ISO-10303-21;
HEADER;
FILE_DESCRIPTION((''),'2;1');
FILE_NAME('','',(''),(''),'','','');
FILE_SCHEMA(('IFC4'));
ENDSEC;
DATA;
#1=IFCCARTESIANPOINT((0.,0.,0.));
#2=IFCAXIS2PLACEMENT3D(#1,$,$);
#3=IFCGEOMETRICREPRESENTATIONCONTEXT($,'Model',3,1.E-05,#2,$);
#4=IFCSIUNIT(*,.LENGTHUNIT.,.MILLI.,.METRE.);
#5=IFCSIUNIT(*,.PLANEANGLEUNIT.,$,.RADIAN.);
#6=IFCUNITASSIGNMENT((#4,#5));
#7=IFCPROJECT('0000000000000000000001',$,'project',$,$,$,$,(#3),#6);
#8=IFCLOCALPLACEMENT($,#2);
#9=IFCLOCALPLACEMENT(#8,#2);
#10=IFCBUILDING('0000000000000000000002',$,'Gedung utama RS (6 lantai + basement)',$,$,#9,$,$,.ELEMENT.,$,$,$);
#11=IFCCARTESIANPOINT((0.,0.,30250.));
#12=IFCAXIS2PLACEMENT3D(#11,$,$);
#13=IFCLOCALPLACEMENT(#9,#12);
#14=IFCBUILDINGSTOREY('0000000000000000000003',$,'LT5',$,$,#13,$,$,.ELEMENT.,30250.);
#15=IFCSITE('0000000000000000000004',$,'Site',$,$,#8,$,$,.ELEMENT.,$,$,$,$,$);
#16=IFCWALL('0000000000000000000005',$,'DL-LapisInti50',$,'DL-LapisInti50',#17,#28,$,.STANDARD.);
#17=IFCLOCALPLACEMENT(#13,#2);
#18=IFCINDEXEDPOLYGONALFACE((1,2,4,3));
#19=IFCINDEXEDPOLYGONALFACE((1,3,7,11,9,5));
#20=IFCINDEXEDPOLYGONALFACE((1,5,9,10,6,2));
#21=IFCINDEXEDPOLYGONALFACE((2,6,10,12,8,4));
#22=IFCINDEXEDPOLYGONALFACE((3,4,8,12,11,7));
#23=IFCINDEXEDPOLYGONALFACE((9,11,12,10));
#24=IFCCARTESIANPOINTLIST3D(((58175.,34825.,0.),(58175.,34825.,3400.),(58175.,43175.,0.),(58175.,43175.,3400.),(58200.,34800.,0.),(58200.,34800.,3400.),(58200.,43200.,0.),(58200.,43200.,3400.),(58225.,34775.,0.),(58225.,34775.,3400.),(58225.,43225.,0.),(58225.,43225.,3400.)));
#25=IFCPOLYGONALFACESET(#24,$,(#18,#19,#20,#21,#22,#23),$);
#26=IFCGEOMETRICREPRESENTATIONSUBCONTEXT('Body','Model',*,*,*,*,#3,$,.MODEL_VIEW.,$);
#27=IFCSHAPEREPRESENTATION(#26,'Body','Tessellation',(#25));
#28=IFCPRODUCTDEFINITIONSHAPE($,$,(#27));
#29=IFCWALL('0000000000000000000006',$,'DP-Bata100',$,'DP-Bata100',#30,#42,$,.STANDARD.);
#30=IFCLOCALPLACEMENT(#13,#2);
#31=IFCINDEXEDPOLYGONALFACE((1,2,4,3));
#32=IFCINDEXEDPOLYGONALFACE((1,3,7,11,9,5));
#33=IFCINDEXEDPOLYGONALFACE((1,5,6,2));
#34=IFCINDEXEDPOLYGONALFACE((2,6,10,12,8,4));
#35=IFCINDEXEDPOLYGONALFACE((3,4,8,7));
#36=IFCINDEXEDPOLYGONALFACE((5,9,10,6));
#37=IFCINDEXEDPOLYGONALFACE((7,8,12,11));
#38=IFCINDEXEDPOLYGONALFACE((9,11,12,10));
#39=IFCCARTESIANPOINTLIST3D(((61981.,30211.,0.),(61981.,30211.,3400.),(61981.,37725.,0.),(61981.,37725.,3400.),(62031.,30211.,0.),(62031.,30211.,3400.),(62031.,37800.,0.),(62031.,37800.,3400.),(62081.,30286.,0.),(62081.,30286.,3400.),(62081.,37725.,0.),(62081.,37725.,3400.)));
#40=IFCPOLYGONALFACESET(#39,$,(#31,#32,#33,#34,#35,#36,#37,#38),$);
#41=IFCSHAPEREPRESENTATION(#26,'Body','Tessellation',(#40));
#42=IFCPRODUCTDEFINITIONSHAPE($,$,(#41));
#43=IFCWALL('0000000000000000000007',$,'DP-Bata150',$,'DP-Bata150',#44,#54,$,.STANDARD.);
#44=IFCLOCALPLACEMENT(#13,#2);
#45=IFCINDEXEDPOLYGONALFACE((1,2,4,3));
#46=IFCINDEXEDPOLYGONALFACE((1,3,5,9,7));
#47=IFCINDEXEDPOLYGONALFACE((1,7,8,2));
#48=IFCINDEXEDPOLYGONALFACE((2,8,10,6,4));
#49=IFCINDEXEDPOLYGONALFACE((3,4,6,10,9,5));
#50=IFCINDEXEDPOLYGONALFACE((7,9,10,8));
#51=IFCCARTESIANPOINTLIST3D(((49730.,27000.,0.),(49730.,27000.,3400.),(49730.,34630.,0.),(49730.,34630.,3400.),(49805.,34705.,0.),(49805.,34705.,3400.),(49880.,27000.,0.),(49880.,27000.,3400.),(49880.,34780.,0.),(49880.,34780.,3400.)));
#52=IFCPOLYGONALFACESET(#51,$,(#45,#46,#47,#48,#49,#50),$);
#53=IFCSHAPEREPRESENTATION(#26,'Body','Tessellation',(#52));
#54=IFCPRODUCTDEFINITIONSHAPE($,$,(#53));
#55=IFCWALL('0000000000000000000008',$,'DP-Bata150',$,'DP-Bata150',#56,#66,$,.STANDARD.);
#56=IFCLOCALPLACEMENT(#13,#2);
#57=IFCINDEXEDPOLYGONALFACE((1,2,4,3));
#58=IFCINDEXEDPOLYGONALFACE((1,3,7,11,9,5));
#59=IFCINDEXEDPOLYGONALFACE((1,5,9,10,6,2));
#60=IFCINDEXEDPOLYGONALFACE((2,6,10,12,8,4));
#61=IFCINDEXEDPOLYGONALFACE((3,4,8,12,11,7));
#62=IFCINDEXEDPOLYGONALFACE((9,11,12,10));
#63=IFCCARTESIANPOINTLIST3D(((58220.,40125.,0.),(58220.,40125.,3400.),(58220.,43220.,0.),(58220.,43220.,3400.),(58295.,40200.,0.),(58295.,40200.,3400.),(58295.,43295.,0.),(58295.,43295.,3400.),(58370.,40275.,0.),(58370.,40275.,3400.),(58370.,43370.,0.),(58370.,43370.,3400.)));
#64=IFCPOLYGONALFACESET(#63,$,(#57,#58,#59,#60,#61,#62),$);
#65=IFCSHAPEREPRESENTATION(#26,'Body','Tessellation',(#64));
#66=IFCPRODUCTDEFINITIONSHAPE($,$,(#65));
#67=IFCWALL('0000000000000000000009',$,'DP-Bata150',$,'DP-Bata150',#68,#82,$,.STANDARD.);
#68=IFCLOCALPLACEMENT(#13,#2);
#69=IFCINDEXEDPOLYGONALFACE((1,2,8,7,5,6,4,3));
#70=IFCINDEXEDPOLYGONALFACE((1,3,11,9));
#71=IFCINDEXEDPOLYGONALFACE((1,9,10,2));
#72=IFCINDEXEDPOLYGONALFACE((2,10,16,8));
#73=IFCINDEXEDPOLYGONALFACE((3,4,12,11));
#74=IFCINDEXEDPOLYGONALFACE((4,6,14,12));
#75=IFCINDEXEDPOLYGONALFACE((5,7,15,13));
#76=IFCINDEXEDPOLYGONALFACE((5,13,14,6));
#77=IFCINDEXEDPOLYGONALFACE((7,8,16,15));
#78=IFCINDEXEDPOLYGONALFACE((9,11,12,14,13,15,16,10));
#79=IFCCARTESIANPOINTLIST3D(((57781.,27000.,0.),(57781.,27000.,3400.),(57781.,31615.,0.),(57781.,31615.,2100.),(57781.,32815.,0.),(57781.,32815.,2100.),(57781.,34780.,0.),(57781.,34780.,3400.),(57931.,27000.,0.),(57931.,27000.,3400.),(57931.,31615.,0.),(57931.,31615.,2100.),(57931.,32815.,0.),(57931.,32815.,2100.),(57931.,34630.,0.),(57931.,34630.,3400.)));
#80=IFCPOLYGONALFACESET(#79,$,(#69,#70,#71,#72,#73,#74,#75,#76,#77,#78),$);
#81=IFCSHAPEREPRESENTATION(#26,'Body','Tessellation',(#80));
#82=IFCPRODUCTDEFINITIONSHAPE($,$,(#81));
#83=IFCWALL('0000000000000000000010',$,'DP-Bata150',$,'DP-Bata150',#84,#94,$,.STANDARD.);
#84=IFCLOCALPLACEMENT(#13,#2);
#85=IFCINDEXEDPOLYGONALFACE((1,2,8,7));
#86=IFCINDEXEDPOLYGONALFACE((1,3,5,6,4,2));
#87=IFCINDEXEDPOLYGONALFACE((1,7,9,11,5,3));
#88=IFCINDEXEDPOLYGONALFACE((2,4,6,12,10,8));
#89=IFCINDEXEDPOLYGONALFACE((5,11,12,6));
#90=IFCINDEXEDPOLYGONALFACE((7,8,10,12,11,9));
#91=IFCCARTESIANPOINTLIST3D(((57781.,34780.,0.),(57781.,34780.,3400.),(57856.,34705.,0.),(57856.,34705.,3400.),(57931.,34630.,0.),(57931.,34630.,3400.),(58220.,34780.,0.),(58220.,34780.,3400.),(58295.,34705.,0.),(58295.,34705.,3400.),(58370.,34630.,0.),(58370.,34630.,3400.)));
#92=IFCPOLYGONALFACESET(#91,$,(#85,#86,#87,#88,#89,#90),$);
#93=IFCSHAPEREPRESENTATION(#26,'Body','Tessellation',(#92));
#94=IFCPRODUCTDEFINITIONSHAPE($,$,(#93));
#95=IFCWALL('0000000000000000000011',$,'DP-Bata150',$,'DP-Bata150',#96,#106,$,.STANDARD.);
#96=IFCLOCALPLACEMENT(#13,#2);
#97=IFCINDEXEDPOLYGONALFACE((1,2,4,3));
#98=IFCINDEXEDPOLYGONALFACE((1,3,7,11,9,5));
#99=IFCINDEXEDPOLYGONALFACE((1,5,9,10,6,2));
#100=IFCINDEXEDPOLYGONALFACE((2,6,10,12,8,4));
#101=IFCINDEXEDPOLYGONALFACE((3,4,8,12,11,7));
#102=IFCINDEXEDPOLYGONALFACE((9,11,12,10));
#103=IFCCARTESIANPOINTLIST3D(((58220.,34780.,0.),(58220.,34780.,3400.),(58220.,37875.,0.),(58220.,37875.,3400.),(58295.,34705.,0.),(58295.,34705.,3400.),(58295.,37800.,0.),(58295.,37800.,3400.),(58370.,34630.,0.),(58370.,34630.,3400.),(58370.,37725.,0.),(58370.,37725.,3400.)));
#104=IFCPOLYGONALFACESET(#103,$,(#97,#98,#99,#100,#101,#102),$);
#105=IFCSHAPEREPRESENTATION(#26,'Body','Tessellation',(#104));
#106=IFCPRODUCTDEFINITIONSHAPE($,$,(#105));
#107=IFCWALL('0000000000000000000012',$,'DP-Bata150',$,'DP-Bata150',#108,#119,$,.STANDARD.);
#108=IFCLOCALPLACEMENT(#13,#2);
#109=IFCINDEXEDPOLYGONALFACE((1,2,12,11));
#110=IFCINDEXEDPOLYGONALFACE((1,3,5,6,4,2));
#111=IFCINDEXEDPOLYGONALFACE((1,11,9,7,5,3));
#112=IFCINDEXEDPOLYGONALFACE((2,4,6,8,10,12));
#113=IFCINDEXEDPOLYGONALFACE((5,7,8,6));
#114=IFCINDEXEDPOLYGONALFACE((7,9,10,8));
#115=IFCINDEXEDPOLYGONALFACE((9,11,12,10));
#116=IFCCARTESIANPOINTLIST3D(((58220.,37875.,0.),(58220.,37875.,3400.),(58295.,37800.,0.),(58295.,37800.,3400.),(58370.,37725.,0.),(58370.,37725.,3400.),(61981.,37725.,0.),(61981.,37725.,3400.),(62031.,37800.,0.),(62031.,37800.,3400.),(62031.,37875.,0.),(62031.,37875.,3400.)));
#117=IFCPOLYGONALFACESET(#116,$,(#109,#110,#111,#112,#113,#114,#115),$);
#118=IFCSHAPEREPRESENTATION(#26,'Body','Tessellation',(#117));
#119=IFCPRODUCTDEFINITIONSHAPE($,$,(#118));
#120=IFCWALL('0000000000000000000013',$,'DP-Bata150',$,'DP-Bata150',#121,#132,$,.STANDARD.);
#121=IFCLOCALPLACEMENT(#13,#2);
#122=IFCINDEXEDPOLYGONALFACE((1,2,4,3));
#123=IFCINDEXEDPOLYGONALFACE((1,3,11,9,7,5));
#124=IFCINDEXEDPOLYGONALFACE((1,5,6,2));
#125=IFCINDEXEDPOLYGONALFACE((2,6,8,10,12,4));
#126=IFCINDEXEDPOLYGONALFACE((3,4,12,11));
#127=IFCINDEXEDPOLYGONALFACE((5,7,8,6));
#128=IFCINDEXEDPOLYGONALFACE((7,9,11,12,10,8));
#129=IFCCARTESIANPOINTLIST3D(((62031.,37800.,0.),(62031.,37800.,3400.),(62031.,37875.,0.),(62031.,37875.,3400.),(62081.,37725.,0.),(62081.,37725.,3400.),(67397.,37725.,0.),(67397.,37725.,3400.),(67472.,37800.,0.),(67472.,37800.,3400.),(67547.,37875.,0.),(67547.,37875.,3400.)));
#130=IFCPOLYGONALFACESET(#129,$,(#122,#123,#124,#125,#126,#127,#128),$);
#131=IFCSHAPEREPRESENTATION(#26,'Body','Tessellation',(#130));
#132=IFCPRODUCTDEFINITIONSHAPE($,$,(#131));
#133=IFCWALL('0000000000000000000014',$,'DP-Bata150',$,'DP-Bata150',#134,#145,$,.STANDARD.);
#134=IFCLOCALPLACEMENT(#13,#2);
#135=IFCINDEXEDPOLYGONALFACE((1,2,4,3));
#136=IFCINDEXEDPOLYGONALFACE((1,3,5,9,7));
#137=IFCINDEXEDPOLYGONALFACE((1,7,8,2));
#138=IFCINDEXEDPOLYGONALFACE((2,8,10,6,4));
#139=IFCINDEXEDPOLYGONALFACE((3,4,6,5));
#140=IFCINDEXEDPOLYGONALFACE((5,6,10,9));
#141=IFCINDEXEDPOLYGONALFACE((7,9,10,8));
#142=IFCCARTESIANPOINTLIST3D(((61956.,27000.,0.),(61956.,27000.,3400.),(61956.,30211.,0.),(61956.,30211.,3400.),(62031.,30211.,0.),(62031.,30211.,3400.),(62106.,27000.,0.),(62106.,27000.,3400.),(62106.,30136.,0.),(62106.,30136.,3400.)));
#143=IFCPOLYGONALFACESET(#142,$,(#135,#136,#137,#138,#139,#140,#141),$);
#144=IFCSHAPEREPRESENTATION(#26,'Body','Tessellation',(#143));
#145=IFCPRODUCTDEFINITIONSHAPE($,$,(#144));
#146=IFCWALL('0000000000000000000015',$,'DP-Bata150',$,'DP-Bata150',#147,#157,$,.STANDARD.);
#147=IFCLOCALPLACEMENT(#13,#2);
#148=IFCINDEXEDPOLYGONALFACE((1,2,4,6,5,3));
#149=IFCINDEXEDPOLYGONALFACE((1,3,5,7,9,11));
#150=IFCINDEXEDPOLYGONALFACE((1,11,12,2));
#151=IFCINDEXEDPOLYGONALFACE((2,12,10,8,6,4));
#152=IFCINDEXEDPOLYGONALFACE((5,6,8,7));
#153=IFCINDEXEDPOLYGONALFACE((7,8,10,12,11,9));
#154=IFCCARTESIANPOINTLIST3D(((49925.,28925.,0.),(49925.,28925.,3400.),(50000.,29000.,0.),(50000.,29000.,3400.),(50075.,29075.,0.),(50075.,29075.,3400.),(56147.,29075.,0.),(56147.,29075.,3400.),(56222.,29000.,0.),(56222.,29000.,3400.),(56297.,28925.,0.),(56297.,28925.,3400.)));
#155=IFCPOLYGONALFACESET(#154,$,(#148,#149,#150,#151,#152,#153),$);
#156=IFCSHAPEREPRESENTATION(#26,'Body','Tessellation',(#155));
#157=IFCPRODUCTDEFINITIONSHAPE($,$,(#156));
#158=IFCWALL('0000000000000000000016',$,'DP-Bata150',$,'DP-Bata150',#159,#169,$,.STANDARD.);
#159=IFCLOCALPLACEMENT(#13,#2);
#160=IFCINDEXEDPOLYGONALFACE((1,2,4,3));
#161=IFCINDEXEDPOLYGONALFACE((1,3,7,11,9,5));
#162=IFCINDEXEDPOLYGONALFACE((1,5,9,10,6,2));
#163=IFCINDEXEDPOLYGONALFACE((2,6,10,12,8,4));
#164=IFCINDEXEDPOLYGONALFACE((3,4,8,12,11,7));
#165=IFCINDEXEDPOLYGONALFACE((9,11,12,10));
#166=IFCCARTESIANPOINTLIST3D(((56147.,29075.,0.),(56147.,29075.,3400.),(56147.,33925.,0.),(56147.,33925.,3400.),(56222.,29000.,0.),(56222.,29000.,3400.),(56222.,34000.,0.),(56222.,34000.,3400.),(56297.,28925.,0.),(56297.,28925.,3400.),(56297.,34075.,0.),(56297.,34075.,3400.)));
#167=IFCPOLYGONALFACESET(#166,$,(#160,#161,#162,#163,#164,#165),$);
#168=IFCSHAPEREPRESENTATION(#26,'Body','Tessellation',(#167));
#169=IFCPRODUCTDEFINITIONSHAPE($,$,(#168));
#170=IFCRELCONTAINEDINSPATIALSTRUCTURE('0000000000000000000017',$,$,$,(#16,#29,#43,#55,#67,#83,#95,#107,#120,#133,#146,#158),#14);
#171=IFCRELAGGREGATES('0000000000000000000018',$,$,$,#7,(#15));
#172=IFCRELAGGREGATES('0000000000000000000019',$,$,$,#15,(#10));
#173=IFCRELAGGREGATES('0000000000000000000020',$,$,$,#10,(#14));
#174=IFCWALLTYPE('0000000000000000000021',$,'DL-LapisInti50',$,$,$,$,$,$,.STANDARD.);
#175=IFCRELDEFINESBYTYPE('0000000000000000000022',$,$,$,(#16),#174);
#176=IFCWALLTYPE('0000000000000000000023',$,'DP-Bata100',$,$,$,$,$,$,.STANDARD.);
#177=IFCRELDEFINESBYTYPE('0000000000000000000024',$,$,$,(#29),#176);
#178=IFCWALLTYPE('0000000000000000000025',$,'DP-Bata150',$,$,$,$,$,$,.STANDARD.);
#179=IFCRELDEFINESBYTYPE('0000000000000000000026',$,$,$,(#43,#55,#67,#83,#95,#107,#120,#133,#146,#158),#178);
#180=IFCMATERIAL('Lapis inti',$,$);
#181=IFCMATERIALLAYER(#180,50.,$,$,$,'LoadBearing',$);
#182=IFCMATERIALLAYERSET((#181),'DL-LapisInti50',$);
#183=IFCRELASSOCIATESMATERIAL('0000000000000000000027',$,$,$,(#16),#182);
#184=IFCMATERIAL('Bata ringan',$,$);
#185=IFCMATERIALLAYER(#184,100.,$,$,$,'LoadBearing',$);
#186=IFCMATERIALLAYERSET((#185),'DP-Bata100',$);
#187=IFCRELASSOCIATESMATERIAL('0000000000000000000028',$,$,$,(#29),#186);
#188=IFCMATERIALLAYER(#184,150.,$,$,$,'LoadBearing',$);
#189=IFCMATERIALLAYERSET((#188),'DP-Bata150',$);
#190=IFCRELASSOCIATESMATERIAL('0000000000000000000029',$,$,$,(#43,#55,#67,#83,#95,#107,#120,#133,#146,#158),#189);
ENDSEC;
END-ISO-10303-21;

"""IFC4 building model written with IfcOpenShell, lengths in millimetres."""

from ifc_helpers import new_model, si_unit, frame, frame_2d, origin, place, context, subcontext, project, spatial, polyline, rectangle, outline, extrude, material, layer, layer_set, layer_usage, type_object, element, save


model = new_model("IFC4")

# Units and contexts
model_context = context("Model", 3, precision=1e-05, world=origin())
body_context = subcontext(model_context, "Body", "Model", "MODEL_VIEW")
ifc_project = project(units=[si_unit("LENGTHUNIT", "METRE", prefix="MILLI"), si_unit("PLANEANGLEUNIT", "RADIAN")], contexts=[model_context])

# Site, building, storey
site_placement = place(None, origin())
site = spatial("IfcSite", under=ifc_project, at=site_placement, Name="Site", CompositionType="ELEMENT")
building_placement = place(site_placement, origin())
building = spatial("IfcBuilding", under=site, at=building_placement, Name="Gedung utama RS (6 lantai + basement)", CompositionType="ELEMENT")
storey_placement = place(building_placement, frame((0.0, 0.0, 30250.0)))
storey = spatial("IfcBuildingStorey", under=building, at=storey_placement, Name="LT5", CompositionType="ELEMENT", Elevation=30250.0)

# Walls
ifc_material_1 = material(Name="Lapis inti")
ifc_layer_1 = layer(ifc_material_1, 50.0, Category="LoadBearing")
ifc_layer_set_1 = layer_set([ifc_layer_1], Name="DL-LapisInti50")
ifc_layer_usage_1 = layer_usage(ifc_layer_set_1, "AXIS2", "NEGATIVE", 25.0)
wall_type_1 = type_object("IfcWallType", Name="DL-LapisInti50", PredefinedType="STANDARD")
wall_1_placement = place(storey_placement, frame((58200.0, 34800.0, 0.0), z_axis=(0.0, 0.0, 1.0), x_axis=(0.0, 1.0, 0.0)))
element("IfcWall", 1, at=wall_1_placement, inside=storey, type_object=wall_type_1, material=ifc_layer_usage_1, Name="DL-LapisInti50", ObjectType="DL-LapisInti50", PredefinedType="STANDARD", context=body_context, shape_type="SweptSolid", body=[
    extrude(outline(polyline([(-25.0, -25.0), (0.0, 0.0), (25.0, 25.0), (8375.0, 25.0), (8400.0, 0.0), (8425.0, -25.0), (-25.0, -25.0)])), origin(), (0.0, 0.0, 1.0), 3400.0),
])
ifc_material_2 = material(Name="Bata ringan")
ifc_layer_2 = layer(ifc_material_2, 100.0, Category="LoadBearing")
ifc_layer_set_2 = layer_set([ifc_layer_2], Name="DP-Bata100")
ifc_layer_usage_2 = layer_usage(ifc_layer_set_2, "AXIS2", "NEGATIVE", 50.0)
wall_type_2 = type_object("IfcWallType", Name="DP-Bata100", PredefinedType="STANDARD")
wall_2_placement = place(storey_placement, frame((62031.0, 37800.0, 0.0), z_axis=(0.0, 0.0, 1.0), x_axis=(0.0, -1.0, 0.0)))
element("IfcWall", 2, at=wall_2_placement, inside=storey, type_object=wall_type_2, material=ifc_layer_usage_2, Name="DP-Bata100", ObjectType="DP-Bata100", PredefinedType="STANDARD", context=body_context, shape_type="SweptSolid", body=[
    extrude(outline(polyline([(75.0, -50.0), (0.0, 0.0), (75.0, 50.0), (7514.0, 50.0), (7589.0, 0.0), (7589.0, -50.0), (75.0, -50.0)])), origin(), (0.0, 0.0, 1.0), 3400.0),
])
ifc_layer_3 = layer(ifc_material_2, 150.0, Category="LoadBearing")
ifc_layer_set_3 = layer_set([ifc_layer_3], Name="DP-Bata150")
ifc_layer_usage_3 = layer_usage(ifc_layer_set_3, "AXIS2", "NEGATIVE", 75.0)
wall_type_3 = type_object("IfcWallType", Name="DP-Bata150", PredefinedType="STANDARD")
wall_3_placement = place(storey_placement, frame((49805.0, 34705.0, 0.0), z_axis=(0.0, 0.0, 1.0), x_axis=(0.0, -1.0, 0.0)))
element("IfcWall", 3, at=wall_3_placement, inside=storey, type_object=wall_type_3, material=ifc_layer_usage_3, Name="DP-Bata150", ObjectType="DP-Bata150", PredefinedType="STANDARD", context=body_context, shape_type="SweptSolid", body=[
    extrude(outline(polyline([(75.0, -75.0), (0.0, 0.0), (-75.0, 75.0), (7705.0, 75.0), (7705.0, -75.0), (75.0, -75.0)])), origin(), (0.0, 0.0, 1.0), 3400.0),
])
wall_4_placement = place(storey_placement, frame((58295.0, 40200.0, 0.0), z_axis=(0.0, 0.0, 1.0), x_axis=(0.0, 1.0, 0.0)))
element("IfcWall", 4, at=wall_4_placement, inside=storey, type_object=wall_type_3, material=ifc_layer_usage_3, Name="DP-Bata150", ObjectType="DP-Bata150", PredefinedType="STANDARD", context=body_context, shape_type="SweptSolid", body=[
    extrude(outline(polyline([(75.0, -75.0), (0.0, 0.0), (-75.0, 75.0), (3020.0, 75.0), (3095.0, 0.0), (3170.0, -75.0), (75.0, -75.0)])), origin(), (0.0, 0.0, 1.0), 3400.0),
])

# Wall, opening
wall_5_placement = place(storey_placement, frame((57856.0, 27000.0, 0.0), z_axis=(0.0, 0.0, 1.0), x_axis=(0.0, 1.0, 0.0)))
wall_5 = element("IfcWall", 5, at=wall_5_placement, inside=storey, type_object=wall_type_3, material=ifc_layer_usage_3, Name="DP-Bata150", ObjectType="DP-Bata150", PredefinedType="STANDARD", context=body_context, shape_type="SweptSolid", body=[
    extrude(outline(polyline([(0.0, -75.0), (0.0, 75.0), (7780.0, 75.0), (7705.0, 0.0), (7630.0, -75.0), (0.0, -75.0)])), origin(), (0.0, 0.0, 1.0), 3400.0),
])
opening_1_placement = place(wall_5_placement, frame((4615.0, 0.0, 0.0), z_axis=(0.0, 0.0, 1.0), x_axis=(1.0, 0.0, 0.0)))
element("IfcOpeningElement", 6, at=opening_1_placement, cuts=wall_5, PredefinedType="OPENING", context=body_context, shape_type="SweptSolid", body=[
    extrude(rectangle(XDim=1200.0, YDim=170.0, at=frame_2d((600.0, 0.0))), origin(), (0.0, 0.0, 1.0), 2100.0),
])

# Walls
wall_6_placement = place(storey_placement, frame((57856.0, 34705.0, 0.0), z_axis=(0.0, 0.0, 1.0), x_axis=(1.0, 0.0, 0.0)))
element("IfcWall", 7, at=wall_6_placement, inside=storey, type_object=wall_type_3, material=ifc_layer_usage_3, Name="DP-Bata150", ObjectType="DP-Bata150", PredefinedType="STANDARD", context=body_context, shape_type="SweptSolid", body=[
    extrude(outline(polyline([(75.0, -75.0), (0.0, 0.0), (-75.0, 75.0), (364.0, 75.0), (439.0, 0.0), (514.0, -75.0), (75.0, -75.0)])), origin(), (0.0, 0.0, 1.0), 3400.0),
])
wall_7_placement = place(storey_placement, frame((58295.0, 34705.0, 0.0), z_axis=(0.0, 0.0, 1.0), x_axis=(0.0, 1.0, 0.0)))
element("IfcWall", 8, at=wall_7_placement, inside=storey, type_object=wall_type_3, material=ifc_layer_usage_3, Name="DP-Bata150", ObjectType="DP-Bata150", PredefinedType="STANDARD", context=body_context, shape_type="SweptSolid", body=[
    extrude(outline(polyline([(-75.0, -75.0), (0.0, 0.0), (75.0, 75.0), (3170.0, 75.0), (3095.0, 0.0), (3020.0, -75.0), (-75.0, -75.0)])), origin(), (0.0, 0.0, 1.0), 3400.0),
])
wall_8_placement = place(storey_placement, frame((58295.0, 37800.0, 0.0), z_axis=(0.0, 0.0, 1.0), x_axis=(1.0, 0.0, 0.0)))
element("IfcWall", 9, at=wall_8_placement, inside=storey, type_object=wall_type_3, material=ifc_layer_usage_3, Name="DP-Bata150", ObjectType="DP-Bata150", PredefinedType="STANDARD", context=body_context, shape_type="SweptSolid", body=[
    extrude(outline(polyline([(75.0, -75.0), (0.0, 0.0), (-75.0, 75.0), (3736.0, 75.0), (3736.0, 0.0), (3686.0, -75.0), (75.0, -75.0)])), origin(), (0.0, 0.0, 1.0), 3400.0),
])
wall_9_placement = place(storey_placement, frame((62031.0, 37800.0, 0.0), z_axis=(0.0, 0.0, 1.0), x_axis=(1.0, 0.0, 0.0)))
element("IfcWall", 10, at=wall_9_placement, inside=storey, type_object=wall_type_3, material=ifc_layer_usage_3, Name="DP-Bata150", ObjectType="DP-Bata150", PredefinedType="STANDARD", context=body_context, shape_type="SweptSolid", body=[
    extrude(outline(polyline([(50.0, -75.0), (0.0, 0.0), (0.0, 75.0), (5516.0, 75.0), (5441.0, 0.0), (5366.0, -75.0), (50.0, -75.0)])), origin(), (0.0, 0.0, 1.0), 3400.0),
])
wall_10_placement = place(storey_placement, frame((62031.0, 30211.0, 0.0), z_axis=(0.0, 0.0, 1.0), x_axis=(0.0, -1.0, 0.0)))
element("IfcWall", 11, at=wall_10_placement, inside=storey, type_object=wall_type_3, material=ifc_layer_usage_3, Name="DP-Bata150", ObjectType="DP-Bata150", PredefinedType="STANDARD", context=body_context, shape_type="SweptSolid", body=[
    extrude(outline(polyline([(0.0, -75.0), (0.0, 0.0), (75.0, 75.0), (3211.0, 75.0), (3211.0, -75.0), (0.0, -75.0)])), origin(), (0.0, 0.0, 1.0), 3400.0),
])
wall_11_placement = place(storey_placement, frame((50000.0, 29000.0, 0.0), z_axis=(0.0, 0.0, 1.0), x_axis=(1.0, 0.0, 0.0)))
element("IfcWall", 12, at=wall_11_placement, inside=storey, type_object=wall_type_3, material=ifc_layer_usage_3, Name="DP-Bata150", ObjectType="DP-Bata150", PredefinedType="STANDARD", context=body_context, shape_type="SweptSolid", body=[
    extrude(outline(polyline([(-75.0, -75.0), (0.0, 0.0), (75.0, 75.0), (6147.0, 75.0), (6222.0, 0.0), (6297.0, -75.0), (-75.0, -75.0)])), origin(), (0.0, 0.0, 1.0), 3400.0),
])
wall_12_placement = place(storey_placement, frame((56222.0, 29000.0, 0.0), z_axis=(0.0, 0.0, 1.0), x_axis=(0.0, 1.0, 0.0)))
element("IfcWall", 13, at=wall_12_placement, inside=storey, type_object=wall_type_3, material=ifc_layer_usage_3, Name="DP-Bata150", ObjectType="DP-Bata150", PredefinedType="STANDARD", context=body_context, shape_type="SweptSolid", body=[
    extrude(outline(polyline([(-75.0, -75.0), (0.0, 0.0), (75.0, 75.0), (4925.0, 75.0), (5000.0, 0.0), (5075.0, -75.0), (-75.0, -75.0)])), origin(), (0.0, 0.0, 1.0), 3400.0),
])

save(model, "model.ifc")
